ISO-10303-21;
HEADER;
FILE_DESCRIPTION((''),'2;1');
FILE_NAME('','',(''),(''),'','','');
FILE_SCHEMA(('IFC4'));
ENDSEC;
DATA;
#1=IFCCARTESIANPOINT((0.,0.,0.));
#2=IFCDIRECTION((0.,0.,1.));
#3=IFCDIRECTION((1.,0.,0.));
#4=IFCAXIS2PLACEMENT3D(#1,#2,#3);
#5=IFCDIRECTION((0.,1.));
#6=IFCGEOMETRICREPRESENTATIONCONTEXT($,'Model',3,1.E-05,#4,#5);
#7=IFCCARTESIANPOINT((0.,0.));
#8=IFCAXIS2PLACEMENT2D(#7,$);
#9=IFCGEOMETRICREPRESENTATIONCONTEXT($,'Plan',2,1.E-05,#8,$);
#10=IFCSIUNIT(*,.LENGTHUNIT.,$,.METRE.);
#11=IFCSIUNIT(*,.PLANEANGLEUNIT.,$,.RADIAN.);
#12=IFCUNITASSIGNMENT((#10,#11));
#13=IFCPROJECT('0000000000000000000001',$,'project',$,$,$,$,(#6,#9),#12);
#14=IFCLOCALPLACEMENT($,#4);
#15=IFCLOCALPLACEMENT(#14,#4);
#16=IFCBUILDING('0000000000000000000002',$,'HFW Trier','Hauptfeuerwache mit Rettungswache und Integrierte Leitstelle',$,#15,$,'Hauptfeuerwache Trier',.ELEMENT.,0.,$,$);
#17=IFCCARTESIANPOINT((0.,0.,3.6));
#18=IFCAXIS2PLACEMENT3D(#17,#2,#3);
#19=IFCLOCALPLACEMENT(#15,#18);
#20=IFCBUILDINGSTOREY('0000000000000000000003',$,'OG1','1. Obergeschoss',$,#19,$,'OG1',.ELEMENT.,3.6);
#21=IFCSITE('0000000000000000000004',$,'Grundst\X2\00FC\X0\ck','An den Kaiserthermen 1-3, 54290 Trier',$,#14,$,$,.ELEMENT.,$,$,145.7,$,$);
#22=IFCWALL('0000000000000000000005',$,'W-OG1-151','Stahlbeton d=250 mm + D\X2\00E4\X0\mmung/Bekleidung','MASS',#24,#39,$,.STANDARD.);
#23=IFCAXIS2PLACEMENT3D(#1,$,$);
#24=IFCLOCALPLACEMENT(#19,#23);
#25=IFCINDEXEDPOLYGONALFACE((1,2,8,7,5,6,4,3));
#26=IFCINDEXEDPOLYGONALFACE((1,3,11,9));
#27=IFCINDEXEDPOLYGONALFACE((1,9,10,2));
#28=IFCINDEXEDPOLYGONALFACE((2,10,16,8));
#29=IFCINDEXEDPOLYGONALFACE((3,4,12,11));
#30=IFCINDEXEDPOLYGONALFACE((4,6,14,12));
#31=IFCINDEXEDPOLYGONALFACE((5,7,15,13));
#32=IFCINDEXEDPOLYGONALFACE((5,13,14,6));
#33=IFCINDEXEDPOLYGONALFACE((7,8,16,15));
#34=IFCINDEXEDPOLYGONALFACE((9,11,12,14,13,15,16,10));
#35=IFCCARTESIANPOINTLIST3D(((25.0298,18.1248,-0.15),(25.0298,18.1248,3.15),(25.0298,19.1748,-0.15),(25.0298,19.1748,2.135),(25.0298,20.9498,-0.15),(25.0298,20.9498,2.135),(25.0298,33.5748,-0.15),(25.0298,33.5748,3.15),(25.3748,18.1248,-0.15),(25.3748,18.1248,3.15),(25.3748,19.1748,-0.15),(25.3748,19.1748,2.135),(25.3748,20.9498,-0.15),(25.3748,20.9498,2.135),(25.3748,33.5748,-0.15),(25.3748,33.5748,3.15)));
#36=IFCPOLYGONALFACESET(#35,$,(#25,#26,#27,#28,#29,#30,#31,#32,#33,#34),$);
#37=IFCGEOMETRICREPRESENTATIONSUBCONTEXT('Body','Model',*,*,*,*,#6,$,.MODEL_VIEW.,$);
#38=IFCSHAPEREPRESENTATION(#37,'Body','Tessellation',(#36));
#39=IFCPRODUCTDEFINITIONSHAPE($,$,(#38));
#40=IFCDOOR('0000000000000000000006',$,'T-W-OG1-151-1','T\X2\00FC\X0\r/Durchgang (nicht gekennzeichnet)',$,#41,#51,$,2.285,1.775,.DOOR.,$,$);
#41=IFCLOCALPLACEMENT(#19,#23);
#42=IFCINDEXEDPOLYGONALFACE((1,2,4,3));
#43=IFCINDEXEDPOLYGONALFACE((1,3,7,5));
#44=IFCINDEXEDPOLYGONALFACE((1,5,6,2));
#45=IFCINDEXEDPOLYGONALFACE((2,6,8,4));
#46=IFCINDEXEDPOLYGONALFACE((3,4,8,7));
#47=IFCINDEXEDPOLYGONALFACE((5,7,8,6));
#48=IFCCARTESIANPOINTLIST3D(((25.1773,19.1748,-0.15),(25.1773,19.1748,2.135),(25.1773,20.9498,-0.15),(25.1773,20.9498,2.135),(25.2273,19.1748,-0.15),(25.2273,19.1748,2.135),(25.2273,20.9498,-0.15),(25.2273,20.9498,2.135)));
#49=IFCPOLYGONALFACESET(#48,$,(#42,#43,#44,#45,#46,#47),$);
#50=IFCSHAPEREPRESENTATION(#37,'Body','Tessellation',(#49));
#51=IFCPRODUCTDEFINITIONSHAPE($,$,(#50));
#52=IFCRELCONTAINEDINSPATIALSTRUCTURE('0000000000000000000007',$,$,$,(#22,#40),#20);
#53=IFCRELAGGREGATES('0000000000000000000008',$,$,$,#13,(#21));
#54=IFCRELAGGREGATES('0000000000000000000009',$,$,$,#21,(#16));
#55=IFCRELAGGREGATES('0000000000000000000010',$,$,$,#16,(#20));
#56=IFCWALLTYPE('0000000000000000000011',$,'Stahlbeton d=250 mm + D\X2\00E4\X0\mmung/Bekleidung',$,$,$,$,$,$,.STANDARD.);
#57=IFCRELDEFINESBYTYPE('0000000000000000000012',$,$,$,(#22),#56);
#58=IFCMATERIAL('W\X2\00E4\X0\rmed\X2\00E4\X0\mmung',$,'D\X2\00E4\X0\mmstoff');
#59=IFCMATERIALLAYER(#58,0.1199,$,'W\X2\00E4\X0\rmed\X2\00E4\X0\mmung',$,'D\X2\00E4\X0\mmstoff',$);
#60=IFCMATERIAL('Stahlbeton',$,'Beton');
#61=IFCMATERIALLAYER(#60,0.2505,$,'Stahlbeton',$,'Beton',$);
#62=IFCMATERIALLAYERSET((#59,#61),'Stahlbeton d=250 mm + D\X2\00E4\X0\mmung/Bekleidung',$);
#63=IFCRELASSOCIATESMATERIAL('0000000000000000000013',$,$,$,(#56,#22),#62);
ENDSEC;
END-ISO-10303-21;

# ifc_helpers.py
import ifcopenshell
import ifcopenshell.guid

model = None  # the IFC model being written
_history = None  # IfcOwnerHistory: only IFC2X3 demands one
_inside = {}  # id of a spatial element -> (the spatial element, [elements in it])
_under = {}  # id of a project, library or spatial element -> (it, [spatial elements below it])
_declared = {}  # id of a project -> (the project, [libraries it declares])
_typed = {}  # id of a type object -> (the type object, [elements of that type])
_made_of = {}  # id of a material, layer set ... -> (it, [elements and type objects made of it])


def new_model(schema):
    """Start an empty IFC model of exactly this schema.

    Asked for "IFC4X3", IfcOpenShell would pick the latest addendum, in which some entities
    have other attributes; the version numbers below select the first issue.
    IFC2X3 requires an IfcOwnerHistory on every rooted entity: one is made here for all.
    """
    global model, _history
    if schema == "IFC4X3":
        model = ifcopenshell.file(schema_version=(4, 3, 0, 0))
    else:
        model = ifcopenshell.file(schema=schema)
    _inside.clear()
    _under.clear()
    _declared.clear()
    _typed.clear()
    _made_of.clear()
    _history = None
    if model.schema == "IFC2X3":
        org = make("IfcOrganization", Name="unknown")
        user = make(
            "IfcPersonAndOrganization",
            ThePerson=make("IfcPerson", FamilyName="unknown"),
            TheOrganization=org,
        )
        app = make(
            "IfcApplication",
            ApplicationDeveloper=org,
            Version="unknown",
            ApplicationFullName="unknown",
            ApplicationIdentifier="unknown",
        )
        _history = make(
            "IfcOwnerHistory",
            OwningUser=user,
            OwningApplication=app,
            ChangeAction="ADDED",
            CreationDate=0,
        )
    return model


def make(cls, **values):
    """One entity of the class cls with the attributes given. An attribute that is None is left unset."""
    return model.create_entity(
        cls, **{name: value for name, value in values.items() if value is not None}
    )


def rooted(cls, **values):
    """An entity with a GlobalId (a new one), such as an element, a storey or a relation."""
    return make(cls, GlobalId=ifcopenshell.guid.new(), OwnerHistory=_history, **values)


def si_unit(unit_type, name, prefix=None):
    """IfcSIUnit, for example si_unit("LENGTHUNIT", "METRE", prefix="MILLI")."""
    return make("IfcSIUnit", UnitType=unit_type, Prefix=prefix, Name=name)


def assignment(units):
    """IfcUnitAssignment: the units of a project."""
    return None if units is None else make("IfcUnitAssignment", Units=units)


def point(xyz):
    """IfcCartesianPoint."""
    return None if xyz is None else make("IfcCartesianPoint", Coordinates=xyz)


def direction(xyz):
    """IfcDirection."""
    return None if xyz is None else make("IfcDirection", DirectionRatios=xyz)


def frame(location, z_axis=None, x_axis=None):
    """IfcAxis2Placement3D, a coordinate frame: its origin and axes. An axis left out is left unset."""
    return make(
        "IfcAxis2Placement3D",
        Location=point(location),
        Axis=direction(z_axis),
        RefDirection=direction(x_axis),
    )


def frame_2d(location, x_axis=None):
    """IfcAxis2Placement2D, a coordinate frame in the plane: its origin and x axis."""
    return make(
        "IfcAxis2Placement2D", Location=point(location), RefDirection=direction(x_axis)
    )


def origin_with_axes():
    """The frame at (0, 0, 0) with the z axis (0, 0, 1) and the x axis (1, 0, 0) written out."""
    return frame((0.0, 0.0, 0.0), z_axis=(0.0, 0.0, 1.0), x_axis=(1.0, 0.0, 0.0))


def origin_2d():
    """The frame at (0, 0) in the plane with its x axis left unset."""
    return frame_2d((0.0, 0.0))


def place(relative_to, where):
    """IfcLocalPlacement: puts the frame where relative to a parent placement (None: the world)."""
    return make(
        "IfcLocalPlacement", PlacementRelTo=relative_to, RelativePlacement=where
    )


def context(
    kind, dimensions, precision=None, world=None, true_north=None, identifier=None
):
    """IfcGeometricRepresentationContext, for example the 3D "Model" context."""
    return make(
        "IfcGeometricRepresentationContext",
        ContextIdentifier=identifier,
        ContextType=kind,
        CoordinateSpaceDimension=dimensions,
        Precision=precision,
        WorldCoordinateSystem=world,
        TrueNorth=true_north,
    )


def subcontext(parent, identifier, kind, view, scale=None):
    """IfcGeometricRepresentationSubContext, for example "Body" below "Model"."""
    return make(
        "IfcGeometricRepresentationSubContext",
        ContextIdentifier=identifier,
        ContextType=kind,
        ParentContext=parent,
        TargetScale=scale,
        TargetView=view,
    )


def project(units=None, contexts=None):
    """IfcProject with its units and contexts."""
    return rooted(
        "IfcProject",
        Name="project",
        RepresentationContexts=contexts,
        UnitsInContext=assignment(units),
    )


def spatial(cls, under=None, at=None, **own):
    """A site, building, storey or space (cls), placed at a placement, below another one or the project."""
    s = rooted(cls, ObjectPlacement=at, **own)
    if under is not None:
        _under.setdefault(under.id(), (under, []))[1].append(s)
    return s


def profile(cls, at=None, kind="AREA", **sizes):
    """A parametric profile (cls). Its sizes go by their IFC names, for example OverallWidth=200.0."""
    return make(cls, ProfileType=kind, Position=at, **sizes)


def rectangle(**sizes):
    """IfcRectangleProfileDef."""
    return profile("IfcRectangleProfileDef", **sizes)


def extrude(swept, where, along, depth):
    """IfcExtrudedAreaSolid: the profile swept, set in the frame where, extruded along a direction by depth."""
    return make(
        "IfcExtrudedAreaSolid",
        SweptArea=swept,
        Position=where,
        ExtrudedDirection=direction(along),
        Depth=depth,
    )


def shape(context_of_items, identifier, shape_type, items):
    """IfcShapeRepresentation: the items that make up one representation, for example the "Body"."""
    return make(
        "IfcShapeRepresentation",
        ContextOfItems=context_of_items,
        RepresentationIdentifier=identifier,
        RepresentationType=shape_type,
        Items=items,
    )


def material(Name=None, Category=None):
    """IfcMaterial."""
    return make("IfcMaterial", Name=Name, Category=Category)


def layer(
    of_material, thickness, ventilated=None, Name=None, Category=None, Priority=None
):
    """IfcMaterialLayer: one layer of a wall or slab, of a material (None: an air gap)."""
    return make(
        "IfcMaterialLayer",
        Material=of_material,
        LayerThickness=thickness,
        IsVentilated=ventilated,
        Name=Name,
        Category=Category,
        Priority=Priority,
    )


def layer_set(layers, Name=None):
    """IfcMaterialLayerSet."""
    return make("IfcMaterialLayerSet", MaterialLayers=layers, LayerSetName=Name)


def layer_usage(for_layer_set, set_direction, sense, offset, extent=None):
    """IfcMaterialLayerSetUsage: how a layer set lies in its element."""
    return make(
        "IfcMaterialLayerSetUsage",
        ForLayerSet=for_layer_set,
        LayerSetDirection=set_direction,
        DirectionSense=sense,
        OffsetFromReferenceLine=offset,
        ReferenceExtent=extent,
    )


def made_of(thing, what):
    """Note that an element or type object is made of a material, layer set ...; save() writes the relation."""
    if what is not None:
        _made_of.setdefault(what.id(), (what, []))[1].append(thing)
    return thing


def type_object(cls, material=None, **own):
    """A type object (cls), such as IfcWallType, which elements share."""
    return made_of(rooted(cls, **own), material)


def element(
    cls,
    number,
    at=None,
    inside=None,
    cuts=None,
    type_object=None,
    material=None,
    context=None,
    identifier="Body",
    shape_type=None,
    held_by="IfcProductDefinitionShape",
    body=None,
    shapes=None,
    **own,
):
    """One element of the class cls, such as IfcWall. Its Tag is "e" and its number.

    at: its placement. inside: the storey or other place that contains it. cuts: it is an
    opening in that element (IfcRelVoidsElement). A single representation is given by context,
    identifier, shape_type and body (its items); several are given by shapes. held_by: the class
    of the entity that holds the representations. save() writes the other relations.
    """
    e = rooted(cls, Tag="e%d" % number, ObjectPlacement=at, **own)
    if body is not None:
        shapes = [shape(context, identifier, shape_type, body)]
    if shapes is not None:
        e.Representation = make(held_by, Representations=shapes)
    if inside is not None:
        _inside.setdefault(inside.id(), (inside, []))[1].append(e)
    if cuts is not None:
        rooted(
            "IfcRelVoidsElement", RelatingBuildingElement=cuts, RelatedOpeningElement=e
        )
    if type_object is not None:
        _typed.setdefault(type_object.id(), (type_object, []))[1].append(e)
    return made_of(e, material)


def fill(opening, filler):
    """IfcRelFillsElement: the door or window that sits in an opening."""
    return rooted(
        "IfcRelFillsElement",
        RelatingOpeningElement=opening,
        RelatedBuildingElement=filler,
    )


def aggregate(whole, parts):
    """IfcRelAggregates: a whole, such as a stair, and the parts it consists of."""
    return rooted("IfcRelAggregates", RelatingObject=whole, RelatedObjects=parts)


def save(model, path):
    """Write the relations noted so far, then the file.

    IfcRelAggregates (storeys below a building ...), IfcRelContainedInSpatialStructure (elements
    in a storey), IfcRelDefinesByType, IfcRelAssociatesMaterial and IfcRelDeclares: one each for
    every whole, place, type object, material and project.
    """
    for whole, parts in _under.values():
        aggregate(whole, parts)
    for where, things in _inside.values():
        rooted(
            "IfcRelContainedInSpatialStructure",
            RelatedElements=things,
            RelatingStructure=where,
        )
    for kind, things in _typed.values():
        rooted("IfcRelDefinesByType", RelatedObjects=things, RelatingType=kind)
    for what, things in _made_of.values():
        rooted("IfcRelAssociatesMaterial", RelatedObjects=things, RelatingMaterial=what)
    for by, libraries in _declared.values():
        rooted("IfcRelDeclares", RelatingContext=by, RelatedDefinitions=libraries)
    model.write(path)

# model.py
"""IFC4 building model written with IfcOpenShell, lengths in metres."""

from ifc_helpers import new_model, si_unit, direction, frame, frame_2d, origin_with_axes, origin_2d, place, context, subcontext, project, spatial, rectangle, extrude, material, layer, layer_set, layer_usage, type_object, element, fill, save


model = new_model("IFC4")

# Units and contexts
model_context = context("Model", 3, precision=1e-05, world=origin_with_axes(), true_north=direction((0.0, 1.0)))
plan_context = context("Plan", 2, precision=1e-05, world=origin_2d())
body_context = subcontext(model_context, "Body", "Model", "MODEL_VIEW")
ifc_project = project(units=[si_unit("LENGTHUNIT", "METRE"), si_unit("PLANEANGLEUNIT", "RADIAN")], contexts=[model_context, plan_context])

# Site, building, storey
site_placement = place(None, origin_with_axes())
site = spatial("IfcSite", under=ifc_project, at=site_placement, Name="Grundstück", Description="An den Kaiserthermen 1-3, 54290 Trier", CompositionType="ELEMENT", RefElevation=145.7)
building_placement = place(site_placement, origin_with_axes())
building = spatial("IfcBuilding", under=site, at=building_placement, Name="HFW Trier", Description="Hauptfeuerwache mit Rettungswache und Integrierte Leitstelle", LongName="Hauptfeuerwache Trier", CompositionType="ELEMENT", ElevationOfRefHeight=0.0)
storey_placement = place(building_placement, frame((0.0, 0.0, 3.6), z_axis=(0.0, 0.0, 1.0), x_axis=(1.0, 0.0, 0.0)))
storey = spatial("IfcBuildingStorey", under=building, at=storey_placement, Name="OG1", Description="1. Obergeschoss", LongName="OG1", CompositionType="ELEMENT", Elevation=3.6)

# Shared definitions
ifc_material_1 = material(Name="Stahlbeton", Category="Beton")

# Wall, opening, door
ifc_material_2 = material(Name="Wärmedämmung", Category="Dämmstoff")
ifc_layer_1 = layer(ifc_material_2, 0.1199, Name="Wärmedämmung", Category="Dämmstoff")
ifc_layer_2 = layer(ifc_material_1, 0.2505, Name="Stahlbeton", Category="Beton")
ifc_layer_set_1 = layer_set([ifc_layer_1, ifc_layer_2], Name="Stahlbeton d=250 mm + Dämmung/Bekleidung")
ifc_layer_usage_1 = layer_usage(ifc_layer_set_1, "AXIS2", "POSITIVE", -0.1724)
wall_type_1 = type_object("IfcWallType", Name="Stahlbeton d=250 mm + Dämmung/Bekleidung", PredefinedType="STANDARD", material=ifc_layer_set_1)
wall_1_placement = place(storey_placement, frame((25.2023, 33.5748, -0.15), z_axis=(0.0, 0.0, 1.0), x_axis=(0.0, -1.0, 0.0)))
wall_1 = element("IfcWall", 1, at=wall_1_placement, inside=storey, type_object=wall_type_1, material=ifc_layer_usage_1, Name="W-OG1-151", Description="Stahlbeton d=250 mm + Dämmung/Bekleidung", ObjectType="MASS", PredefinedType="STANDARD", context=body_context, shape_type="SweptSolid", body=[
    extrude(rectangle(XDim=15.45, YDim=0.3449, at=frame_2d((7.725, 0.0))), origin_with_axes(), (0.0, 0.0, 1.0), 3.3),
])
opening_placement = place(wall_1_placement, frame((12.625, 0.0, 0.0), z_axis=(0.0, 0.0, 1.0), x_axis=(1.0, 0.0, 0.0)))
opening = element("IfcOpeningElement", 2, at=opening_placement, cuts=wall_1, PredefinedType="OPENING", context=body_context, shape_type="SweptSolid", body=[
    extrude(rectangle(XDim=1.775, YDim=0.4449, at=frame_2d((0.8875, 0.0))), origin_with_axes(), (0.0, 0.0, 1.0), 2.285),
])
door_placement = place(wall_1_placement, frame((12.625, 0.0, 0.0), z_axis=(0.0, 0.0, 1.0), x_axis=(1.0, 0.0, 0.0)))
door = element("IfcDoor", 3, at=door_placement, inside=storey, Name="T-W-OG1-151-1", Description="Tür/Durchgang (nicht gekennzeichnet)", OverallHeight=2.285, OverallWidth=1.775, PredefinedType="DOOR", context=body_context, shape_type="SweptSolid", body=[
    extrude(rectangle(XDim=1.775, YDim=0.05, at=frame_2d((0.8875, 0.0))), origin_with_axes(), (0.0, 0.0, 1.0), 2.285),
])
fill(opening, door)

save(model, "model.ifc")
